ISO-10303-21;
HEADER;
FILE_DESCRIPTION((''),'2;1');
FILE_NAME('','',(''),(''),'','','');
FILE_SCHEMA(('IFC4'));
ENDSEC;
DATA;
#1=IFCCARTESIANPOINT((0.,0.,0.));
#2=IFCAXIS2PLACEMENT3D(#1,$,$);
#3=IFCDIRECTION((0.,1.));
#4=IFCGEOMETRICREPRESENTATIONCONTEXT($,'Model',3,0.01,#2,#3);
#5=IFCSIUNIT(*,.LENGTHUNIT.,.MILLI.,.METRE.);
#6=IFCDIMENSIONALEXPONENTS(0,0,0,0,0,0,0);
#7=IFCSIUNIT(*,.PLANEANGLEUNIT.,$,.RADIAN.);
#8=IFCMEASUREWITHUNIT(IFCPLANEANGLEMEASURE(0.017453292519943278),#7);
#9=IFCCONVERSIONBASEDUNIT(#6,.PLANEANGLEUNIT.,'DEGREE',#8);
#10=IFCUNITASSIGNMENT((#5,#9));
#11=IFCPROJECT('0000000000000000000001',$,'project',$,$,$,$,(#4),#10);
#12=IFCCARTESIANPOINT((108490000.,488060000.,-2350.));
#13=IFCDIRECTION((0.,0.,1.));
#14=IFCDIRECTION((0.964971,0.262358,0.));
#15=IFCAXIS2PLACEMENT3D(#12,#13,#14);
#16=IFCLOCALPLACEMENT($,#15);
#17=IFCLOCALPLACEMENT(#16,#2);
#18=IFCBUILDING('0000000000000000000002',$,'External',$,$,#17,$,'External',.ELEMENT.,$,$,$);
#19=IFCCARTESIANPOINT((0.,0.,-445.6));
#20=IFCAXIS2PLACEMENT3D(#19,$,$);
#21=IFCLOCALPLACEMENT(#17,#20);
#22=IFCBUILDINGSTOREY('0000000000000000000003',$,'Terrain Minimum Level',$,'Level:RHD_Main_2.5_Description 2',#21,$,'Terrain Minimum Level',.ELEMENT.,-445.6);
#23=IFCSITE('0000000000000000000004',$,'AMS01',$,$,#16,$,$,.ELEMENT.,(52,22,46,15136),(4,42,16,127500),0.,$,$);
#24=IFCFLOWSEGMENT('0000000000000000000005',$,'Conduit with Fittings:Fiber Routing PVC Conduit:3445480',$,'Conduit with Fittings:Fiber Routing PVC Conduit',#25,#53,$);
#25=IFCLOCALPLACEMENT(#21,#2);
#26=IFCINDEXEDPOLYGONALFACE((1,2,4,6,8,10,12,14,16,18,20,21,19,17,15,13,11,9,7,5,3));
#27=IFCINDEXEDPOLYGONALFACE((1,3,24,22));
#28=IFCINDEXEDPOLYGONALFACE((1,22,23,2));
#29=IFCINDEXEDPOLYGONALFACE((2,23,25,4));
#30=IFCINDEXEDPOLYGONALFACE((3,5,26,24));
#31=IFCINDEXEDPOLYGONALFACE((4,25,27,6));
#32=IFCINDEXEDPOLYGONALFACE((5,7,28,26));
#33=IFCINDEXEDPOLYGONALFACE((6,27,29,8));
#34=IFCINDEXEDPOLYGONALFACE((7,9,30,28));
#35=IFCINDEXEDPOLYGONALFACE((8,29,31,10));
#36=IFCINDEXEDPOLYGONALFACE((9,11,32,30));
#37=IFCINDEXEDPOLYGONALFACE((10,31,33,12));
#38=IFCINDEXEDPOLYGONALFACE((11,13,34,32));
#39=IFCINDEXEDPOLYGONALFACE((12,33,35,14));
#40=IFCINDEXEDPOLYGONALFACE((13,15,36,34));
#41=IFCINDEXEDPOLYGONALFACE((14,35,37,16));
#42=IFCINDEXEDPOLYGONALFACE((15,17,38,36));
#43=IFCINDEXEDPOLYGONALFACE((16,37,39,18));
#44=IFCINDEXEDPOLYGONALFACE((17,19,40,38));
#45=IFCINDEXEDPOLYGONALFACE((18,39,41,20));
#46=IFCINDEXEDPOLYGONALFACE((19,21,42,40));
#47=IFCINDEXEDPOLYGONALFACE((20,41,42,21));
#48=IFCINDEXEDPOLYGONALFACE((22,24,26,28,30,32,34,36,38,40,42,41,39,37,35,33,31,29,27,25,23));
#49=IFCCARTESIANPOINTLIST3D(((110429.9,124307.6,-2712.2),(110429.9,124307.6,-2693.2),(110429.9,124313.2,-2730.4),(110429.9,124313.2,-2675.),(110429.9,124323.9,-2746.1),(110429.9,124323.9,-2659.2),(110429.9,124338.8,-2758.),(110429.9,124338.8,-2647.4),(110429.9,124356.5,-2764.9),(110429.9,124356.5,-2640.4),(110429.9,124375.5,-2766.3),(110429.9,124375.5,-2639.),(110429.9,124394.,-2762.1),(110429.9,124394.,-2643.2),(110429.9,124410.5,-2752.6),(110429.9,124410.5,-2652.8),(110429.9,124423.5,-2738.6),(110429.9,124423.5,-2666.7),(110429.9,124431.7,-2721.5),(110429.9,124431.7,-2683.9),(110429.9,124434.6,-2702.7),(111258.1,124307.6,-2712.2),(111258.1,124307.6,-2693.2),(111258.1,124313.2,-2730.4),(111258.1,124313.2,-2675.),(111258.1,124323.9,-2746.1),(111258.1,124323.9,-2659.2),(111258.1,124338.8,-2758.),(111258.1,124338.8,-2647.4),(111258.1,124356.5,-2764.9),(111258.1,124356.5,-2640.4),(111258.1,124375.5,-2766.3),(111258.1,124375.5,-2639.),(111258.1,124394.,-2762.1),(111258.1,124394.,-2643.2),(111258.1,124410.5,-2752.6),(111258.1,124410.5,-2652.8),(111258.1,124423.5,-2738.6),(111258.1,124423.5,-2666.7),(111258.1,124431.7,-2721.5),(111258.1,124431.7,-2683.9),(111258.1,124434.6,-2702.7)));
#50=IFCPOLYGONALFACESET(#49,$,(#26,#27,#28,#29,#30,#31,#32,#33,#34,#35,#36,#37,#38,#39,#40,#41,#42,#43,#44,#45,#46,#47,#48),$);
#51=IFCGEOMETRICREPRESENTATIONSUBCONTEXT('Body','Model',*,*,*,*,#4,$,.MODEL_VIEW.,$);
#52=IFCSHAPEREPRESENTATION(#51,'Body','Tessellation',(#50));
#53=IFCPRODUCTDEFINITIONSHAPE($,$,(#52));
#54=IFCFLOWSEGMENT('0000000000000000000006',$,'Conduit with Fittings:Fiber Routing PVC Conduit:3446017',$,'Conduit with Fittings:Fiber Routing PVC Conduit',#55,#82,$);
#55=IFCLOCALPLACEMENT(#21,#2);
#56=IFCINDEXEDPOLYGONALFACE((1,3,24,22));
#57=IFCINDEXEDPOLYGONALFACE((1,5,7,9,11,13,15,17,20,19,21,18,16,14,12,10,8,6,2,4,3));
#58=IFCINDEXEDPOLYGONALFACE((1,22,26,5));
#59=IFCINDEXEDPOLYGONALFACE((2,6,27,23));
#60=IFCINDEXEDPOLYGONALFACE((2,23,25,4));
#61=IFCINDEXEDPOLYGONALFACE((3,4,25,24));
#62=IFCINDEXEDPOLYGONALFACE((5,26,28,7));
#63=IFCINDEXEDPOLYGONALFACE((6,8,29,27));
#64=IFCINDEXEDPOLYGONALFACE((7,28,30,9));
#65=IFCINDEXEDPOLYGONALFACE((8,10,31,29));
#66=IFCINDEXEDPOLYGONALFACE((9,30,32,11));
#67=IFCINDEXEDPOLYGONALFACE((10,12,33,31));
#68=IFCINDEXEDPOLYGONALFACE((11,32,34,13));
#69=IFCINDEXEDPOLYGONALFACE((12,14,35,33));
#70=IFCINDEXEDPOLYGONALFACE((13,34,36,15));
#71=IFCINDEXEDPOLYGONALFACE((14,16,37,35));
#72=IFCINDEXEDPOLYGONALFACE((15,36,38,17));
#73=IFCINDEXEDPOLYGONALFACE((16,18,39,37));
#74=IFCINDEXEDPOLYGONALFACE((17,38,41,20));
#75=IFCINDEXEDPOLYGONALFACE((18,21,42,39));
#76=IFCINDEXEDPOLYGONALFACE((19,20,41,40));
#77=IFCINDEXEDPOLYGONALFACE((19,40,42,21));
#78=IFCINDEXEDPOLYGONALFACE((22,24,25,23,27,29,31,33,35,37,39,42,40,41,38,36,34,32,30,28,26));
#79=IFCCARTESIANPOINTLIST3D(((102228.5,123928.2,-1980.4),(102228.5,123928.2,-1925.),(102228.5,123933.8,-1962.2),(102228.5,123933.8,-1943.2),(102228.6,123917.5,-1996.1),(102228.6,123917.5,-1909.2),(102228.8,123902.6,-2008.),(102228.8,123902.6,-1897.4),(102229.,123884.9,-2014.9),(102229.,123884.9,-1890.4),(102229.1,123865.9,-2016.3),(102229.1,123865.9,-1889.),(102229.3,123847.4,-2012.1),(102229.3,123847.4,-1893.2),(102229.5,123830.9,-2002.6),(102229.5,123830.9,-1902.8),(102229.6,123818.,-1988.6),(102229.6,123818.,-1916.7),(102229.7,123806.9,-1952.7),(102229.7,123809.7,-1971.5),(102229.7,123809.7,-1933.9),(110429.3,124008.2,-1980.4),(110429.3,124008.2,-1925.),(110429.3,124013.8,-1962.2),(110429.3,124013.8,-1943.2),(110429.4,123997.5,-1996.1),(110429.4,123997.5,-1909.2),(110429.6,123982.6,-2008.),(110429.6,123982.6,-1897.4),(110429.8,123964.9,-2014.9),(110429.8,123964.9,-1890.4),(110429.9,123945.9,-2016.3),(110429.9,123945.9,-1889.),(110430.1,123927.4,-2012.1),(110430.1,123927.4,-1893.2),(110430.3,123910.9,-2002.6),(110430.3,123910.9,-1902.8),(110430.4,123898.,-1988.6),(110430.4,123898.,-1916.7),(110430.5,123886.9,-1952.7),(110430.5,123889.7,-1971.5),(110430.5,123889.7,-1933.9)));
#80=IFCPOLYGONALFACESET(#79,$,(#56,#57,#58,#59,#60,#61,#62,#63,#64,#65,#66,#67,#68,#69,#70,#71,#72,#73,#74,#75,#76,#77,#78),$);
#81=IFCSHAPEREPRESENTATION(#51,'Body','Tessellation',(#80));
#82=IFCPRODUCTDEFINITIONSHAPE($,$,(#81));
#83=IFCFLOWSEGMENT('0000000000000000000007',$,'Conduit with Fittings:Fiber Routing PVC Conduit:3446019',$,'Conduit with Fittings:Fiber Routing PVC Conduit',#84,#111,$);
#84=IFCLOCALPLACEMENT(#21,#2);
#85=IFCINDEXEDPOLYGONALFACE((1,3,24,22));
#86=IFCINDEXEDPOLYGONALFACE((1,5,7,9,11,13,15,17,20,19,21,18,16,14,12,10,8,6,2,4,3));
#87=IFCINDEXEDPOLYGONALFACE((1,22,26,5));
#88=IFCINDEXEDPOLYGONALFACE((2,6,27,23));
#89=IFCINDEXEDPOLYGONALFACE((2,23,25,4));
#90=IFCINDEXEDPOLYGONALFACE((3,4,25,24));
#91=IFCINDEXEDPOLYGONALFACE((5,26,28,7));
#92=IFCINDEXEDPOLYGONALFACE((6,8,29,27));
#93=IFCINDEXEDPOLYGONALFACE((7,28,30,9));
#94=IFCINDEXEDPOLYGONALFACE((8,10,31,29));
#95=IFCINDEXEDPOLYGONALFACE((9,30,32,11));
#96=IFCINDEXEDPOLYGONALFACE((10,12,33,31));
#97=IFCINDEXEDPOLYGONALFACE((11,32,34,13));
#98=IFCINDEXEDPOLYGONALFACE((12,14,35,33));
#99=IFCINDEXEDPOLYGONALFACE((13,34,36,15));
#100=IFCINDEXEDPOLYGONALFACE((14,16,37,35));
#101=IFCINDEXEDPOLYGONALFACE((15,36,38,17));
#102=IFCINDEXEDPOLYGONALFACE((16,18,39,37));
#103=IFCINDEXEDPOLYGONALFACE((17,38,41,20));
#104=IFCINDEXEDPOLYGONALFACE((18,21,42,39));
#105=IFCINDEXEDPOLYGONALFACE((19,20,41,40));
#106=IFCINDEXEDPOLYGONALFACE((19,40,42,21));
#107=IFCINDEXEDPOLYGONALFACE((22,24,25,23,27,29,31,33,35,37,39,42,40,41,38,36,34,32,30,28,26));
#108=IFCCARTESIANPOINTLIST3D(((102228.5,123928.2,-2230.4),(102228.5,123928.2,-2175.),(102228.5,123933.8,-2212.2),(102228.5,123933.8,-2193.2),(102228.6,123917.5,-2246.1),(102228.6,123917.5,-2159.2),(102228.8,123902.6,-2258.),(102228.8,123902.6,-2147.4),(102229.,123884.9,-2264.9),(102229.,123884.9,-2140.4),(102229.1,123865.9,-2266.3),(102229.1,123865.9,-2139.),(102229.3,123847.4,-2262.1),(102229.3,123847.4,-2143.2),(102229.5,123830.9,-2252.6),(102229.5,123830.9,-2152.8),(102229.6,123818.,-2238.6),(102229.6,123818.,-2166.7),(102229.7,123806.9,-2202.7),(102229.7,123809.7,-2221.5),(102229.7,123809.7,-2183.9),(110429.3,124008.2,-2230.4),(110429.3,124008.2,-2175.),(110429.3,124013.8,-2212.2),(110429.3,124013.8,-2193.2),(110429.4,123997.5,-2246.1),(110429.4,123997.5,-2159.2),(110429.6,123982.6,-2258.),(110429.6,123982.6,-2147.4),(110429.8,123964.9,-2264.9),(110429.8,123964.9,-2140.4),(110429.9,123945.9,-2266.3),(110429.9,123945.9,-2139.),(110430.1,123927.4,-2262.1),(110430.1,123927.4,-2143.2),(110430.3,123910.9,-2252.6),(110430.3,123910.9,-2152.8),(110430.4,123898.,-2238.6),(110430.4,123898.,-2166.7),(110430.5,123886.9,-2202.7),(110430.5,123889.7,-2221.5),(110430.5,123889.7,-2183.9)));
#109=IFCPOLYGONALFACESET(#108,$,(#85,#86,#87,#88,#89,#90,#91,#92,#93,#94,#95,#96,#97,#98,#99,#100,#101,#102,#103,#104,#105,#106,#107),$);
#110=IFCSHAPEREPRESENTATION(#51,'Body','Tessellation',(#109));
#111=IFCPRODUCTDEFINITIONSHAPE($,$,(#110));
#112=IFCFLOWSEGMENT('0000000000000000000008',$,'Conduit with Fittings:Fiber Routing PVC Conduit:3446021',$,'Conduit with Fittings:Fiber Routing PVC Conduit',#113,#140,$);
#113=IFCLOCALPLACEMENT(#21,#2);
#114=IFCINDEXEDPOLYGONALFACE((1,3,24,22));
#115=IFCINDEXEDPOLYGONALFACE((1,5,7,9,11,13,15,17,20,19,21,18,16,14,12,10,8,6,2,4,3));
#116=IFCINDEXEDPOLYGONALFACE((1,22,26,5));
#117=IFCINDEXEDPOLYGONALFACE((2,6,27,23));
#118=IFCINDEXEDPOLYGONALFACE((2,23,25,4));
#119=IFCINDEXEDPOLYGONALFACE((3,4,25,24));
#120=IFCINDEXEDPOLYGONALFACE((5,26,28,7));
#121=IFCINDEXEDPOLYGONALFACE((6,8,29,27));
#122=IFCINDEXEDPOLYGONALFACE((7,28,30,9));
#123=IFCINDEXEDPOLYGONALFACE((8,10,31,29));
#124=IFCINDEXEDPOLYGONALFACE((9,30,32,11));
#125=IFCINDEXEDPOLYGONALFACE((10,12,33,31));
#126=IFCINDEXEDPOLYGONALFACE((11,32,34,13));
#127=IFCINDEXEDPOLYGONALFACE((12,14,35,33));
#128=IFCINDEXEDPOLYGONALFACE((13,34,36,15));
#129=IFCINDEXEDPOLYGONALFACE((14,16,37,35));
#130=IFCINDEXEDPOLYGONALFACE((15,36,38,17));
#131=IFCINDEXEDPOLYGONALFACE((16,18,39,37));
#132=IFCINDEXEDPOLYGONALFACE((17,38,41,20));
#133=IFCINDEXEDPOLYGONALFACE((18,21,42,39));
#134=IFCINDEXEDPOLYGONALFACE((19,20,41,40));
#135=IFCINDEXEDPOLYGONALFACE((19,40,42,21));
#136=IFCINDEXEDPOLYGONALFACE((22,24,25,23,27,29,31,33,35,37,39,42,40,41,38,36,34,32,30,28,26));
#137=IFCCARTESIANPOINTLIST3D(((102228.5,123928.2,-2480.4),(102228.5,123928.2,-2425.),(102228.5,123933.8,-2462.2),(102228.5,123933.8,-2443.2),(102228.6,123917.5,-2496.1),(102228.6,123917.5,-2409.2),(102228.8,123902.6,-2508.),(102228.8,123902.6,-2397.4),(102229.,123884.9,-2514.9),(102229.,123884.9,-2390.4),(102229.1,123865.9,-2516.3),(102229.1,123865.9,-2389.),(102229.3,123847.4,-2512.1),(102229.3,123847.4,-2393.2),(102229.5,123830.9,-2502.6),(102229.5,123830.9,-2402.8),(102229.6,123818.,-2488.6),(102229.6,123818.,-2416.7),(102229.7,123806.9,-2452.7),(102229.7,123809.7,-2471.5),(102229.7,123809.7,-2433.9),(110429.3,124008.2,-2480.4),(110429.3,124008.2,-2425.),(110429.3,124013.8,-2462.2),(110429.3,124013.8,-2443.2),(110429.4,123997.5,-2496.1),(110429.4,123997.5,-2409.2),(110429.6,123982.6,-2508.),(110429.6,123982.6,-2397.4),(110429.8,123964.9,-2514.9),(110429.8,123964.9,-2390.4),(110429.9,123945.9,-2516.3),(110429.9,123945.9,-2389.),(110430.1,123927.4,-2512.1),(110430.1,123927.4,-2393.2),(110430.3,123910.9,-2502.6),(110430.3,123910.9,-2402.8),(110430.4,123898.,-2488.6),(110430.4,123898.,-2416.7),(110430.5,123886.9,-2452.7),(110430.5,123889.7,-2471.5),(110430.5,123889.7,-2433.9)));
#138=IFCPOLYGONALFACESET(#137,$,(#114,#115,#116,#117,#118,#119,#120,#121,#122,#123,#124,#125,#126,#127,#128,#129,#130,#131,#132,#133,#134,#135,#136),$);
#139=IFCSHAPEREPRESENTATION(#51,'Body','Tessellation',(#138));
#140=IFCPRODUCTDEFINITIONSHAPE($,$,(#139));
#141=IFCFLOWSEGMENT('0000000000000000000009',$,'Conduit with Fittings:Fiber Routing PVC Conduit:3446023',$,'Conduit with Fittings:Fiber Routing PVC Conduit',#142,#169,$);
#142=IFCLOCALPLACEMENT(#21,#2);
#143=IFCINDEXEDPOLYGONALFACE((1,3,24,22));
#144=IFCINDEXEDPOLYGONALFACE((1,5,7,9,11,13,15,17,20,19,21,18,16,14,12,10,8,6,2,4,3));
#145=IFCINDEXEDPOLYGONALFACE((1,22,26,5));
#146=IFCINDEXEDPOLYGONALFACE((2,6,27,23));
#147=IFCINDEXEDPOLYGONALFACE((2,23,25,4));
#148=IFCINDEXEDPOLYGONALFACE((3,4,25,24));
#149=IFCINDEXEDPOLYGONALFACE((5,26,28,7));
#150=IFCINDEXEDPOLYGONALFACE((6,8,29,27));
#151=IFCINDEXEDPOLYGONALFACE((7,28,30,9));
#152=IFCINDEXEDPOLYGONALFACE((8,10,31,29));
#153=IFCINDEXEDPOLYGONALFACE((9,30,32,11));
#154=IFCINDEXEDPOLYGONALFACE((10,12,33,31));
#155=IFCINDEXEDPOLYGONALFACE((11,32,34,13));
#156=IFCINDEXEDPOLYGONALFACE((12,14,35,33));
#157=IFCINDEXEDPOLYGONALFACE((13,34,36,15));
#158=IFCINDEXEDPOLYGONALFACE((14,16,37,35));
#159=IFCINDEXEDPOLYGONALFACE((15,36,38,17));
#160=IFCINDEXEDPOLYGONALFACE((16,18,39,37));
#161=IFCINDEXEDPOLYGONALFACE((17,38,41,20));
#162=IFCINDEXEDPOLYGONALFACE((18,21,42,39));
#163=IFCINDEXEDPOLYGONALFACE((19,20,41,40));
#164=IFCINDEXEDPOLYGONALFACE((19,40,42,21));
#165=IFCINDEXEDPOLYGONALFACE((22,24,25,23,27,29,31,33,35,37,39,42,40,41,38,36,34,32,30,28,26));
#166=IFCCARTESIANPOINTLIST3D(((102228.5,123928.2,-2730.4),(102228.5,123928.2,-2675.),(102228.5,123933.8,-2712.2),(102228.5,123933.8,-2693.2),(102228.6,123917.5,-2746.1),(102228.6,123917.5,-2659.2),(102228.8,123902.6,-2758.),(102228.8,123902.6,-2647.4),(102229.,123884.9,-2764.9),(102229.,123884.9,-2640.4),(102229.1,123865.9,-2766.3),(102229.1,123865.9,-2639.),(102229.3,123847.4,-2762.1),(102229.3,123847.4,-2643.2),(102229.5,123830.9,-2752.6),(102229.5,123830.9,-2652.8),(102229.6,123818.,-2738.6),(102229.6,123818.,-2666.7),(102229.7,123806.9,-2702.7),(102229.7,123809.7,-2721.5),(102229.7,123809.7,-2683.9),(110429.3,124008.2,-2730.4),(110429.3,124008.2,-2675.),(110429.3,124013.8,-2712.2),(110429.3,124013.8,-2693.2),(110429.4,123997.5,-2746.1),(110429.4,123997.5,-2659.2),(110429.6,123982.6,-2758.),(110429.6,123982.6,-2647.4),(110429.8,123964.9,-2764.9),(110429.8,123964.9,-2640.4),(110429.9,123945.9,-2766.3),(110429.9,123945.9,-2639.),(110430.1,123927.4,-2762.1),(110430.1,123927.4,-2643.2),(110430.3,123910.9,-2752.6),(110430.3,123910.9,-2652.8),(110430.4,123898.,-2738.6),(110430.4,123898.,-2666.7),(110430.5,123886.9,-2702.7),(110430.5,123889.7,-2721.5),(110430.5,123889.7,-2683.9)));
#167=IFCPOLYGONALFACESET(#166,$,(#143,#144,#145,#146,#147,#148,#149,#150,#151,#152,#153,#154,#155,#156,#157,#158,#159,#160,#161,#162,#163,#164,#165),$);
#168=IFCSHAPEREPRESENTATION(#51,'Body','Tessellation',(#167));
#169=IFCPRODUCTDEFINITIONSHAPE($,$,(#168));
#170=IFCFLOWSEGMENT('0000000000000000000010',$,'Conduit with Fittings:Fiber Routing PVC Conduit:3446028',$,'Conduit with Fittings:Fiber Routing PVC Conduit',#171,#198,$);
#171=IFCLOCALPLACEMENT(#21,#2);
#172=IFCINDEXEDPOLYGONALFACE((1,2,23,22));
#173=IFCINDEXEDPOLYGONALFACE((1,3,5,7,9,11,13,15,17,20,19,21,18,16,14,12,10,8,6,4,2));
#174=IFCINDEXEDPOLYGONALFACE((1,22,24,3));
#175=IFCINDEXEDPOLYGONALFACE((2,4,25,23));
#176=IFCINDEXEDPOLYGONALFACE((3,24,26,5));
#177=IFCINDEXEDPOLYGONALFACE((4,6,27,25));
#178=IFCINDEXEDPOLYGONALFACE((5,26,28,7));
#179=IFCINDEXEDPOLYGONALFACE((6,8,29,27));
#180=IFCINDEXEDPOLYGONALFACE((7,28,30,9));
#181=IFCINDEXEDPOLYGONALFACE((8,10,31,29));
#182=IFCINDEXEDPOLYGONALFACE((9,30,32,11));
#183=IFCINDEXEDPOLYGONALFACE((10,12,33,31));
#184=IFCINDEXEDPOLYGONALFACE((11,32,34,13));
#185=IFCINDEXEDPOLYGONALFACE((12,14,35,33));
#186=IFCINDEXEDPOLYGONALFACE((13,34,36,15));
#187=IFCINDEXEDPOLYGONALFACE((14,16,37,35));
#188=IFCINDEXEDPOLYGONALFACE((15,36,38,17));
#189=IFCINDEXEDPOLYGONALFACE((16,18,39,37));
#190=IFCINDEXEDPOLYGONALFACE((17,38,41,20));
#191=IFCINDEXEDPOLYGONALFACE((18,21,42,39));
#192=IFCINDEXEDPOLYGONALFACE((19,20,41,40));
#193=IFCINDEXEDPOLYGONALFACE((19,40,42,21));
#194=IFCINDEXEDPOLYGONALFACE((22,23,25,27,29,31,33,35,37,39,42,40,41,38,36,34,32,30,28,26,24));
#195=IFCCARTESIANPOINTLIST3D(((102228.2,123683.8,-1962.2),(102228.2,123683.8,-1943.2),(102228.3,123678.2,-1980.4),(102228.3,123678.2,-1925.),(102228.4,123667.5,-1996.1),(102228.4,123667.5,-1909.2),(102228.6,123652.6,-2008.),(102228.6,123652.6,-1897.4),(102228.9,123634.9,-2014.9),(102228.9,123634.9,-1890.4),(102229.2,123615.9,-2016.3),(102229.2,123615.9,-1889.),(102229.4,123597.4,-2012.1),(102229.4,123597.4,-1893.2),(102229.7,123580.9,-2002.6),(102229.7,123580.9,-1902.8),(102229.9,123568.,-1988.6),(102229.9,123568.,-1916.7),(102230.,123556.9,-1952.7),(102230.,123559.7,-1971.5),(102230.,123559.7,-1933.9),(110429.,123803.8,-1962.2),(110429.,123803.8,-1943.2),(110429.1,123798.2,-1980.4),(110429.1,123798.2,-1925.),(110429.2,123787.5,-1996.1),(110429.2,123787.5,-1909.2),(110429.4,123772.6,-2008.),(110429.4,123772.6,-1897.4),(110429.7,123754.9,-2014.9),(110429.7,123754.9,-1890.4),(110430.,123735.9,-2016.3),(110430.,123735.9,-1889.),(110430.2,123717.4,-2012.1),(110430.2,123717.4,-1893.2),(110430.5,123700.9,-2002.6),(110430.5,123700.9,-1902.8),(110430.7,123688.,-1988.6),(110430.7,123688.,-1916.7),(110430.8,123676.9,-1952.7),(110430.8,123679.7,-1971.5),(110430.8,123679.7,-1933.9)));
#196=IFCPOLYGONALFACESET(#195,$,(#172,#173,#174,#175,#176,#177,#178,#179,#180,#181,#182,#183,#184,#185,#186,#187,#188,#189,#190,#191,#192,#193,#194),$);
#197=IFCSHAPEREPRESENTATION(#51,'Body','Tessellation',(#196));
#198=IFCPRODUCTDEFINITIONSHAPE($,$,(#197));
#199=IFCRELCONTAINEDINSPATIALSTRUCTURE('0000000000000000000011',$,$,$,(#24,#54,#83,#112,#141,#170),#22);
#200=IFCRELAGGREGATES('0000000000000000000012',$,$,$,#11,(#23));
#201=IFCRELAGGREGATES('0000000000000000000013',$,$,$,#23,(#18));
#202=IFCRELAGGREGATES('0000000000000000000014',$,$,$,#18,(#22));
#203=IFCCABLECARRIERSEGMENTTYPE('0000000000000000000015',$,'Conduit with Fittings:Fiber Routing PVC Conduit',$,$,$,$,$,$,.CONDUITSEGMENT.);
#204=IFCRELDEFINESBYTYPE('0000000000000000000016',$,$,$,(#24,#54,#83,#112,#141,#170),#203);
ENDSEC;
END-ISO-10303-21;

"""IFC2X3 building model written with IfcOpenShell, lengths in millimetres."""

from ifc_helpers import new_model, entity, si_unit, converted_unit, direction, frame, frame_2d, origin, origin_2d_with_axis, place, context, subcontext, project, spatial, circle, extrude, type_object, element, save


model = new_model("IFC2X3")

# Units and contexts
model_context = context("Model", 3, precision=0.01, world=origin(), true_north=direction((0.0, 1.0)))
body_context = subcontext(model_context, "Body", "Model", "MODEL_VIEW")
ifc_project = project(units=[si_unit("LENGTHUNIT", "METRE", prefix="MILLI"), converted_unit("PLANEANGLEUNIT", "DEGREE", entity("IfcPlaneAngleMeasure", 0.017453292519943278), si_unit("PLANEANGLEUNIT", "RADIAN"), dimensions=[0, 0, 0, 0, 0, 0, 0])], contexts=[model_context])

# Site, building, storey
site_placement = place(None, frame((108490000.0, 488060000.0, -2350.0), z_axis=(0.0, 0.0, 1.0), x_axis=(0.964971, 0.262358, 0.0)))
site = spatial("IfcSite", under=ifc_project, at=site_placement, Name="AMS01", CompositionType="ELEMENT", RefLatitude=(52, 22, 46, 15136), RefLongitude=(4, 42, 16, 127500), RefElevation=0.0)
building_placement = place(site_placement, origin())
building = spatial("IfcBuilding", under=site, at=building_placement, Name="External", LongName="External", CompositionType="ELEMENT")
storey_placement = place(building_placement, frame((0.0, 0.0, -445.6)))
storey = spatial("IfcBuildingStorey", under=building, at=storey_placement, Name="Terrain Minimum Level", ObjectType="Level:RHD_Main_2.5_Description 2", LongName="Terrain Minimum Level", CompositionType="ELEMENT", Elevation=-445.6)

# Flow segments
cable_carrier_segment_type = type_object("IfcCableCarrierSegmentType", Name="Conduit with Fittings:Fiber Routing PVC Conduit", PredefinedType="CONDUITSEGMENT")
flow_segment_1_placement = place(storey_placement, origin())
element("IfcFlowSegment", 1, at=flow_segment_1_placement, inside=storey, type_object=cable_carrier_segment_type, Name="Conduit with Fittings:Fiber Routing PVC Conduit:3445480", ObjectType="Conduit with Fittings:Fiber Routing PVC Conduit", context=body_context, shape_type="SweptSolid", body=[
    extrude(circle(Radius=63.9, at=frame_2d((0.0, 0.0), x_axis=(1.0, 0.0))), frame((110429.9, 124370.7, -2702.7), z_axis=(1.0, 0.0, 0.0), x_axis=(0.0, 1.0, 0.0)), (0.0, 0.0, 1.0), 828.2),
])
flow_segment_2_placement = place(storey_placement, origin())
element("IfcFlowSegment", 2, at=flow_segment_2_placement, inside=storey, type_object=cable_carrier_segment_type, Name="Conduit with Fittings:Fiber Routing PVC Conduit:3446017", ObjectType="Conduit with Fittings:Fiber Routing PVC Conduit", context=body_context, shape_type="SweptSolid", body=[
    extrude(circle(Radius=63.9, at=origin_2d_with_axis()), frame((102229.1, 123870.7, -1952.7), z_axis=(0.999952, 0.009755, 0.0), x_axis=(0.009755, -0.999952, 0.0)), (0.0, 0.0, 1.0), 8201.2),
])
flow_segment_3_placement = place(storey_placement, origin())
element("IfcFlowSegment", 3, at=flow_segment_3_placement, inside=storey, type_object=cable_carrier_segment_type, Name="Conduit with Fittings:Fiber Routing PVC Conduit:3446019", ObjectType="Conduit with Fittings:Fiber Routing PVC Conduit", context=body_context, shape_type="SweptSolid", body=[
    extrude(circle(Radius=63.9, at=origin_2d_with_axis()), frame((102229.1, 123870.7, -2202.7), z_axis=(0.999952, 0.009755, 0.0), x_axis=(0.009755, -0.999952, 0.0)), (0.0, 0.0, 1.0), 8201.2),
])
flow_segment_4_placement = place(storey_placement, origin())
element("IfcFlowSegment", 4, at=flow_segment_4_placement, inside=storey, type_object=cable_carrier_segment_type, Name="Conduit with Fittings:Fiber Routing PVC Conduit:3446021", ObjectType="Conduit with Fittings:Fiber Routing PVC Conduit", context=body_context, shape_type="SweptSolid", body=[
    extrude(circle(Radius=63.9, at=origin_2d_with_axis()), frame((102229.1, 123870.7, -2452.7), z_axis=(0.999952, 0.009755, 0.0), x_axis=(0.009755, -0.999952, 0.0)), (0.0, 0.0, 1.0), 8201.2),
])
flow_segment_5_placement = place(storey_placement, origin())
element("IfcFlowSegment", 5, at=flow_segment_5_placement, inside=storey, type_object=cable_carrier_segment_type, Name="Conduit with Fittings:Fiber Routing PVC Conduit:3446023", ObjectType="Conduit with Fittings:Fiber Routing PVC Conduit", context=body_context, shape_type="SweptSolid", body=[
    extrude(circle(Radius=63.9, at=frame_2d((0.0, 0.0), x_axis=(1.0, 0.0))), frame((102229.1, 123870.7, -2702.7), z_axis=(0.999952, 0.009755, 0.0), x_axis=(0.009755, -0.999952, 0.0)), (0.0, 0.0, 1.0), 8201.2),
])
flow_segment_6_placement = place(storey_placement, origin())
element("IfcFlowSegment", 6, at=flow_segment_6_placement, inside=storey, type_object=cable_carrier_segment_type, Name="Conduit with Fittings:Fiber Routing PVC Conduit:3446028", ObjectType="Conduit with Fittings:Fiber Routing PVC Conduit", context=body_context, shape_type="SweptSolid", body=[
    extrude(circle(Radius=63.9, at=origin_2d_with_axis()), frame((102229.1, 123620.7, -1952.7), z_axis=(0.999893, 0.014631, 0.0), x_axis=(0.014631, -0.999893, 0.0)), (0.0, 0.0, 1.0), 8201.7),
])

save(model, "model.ifc")
